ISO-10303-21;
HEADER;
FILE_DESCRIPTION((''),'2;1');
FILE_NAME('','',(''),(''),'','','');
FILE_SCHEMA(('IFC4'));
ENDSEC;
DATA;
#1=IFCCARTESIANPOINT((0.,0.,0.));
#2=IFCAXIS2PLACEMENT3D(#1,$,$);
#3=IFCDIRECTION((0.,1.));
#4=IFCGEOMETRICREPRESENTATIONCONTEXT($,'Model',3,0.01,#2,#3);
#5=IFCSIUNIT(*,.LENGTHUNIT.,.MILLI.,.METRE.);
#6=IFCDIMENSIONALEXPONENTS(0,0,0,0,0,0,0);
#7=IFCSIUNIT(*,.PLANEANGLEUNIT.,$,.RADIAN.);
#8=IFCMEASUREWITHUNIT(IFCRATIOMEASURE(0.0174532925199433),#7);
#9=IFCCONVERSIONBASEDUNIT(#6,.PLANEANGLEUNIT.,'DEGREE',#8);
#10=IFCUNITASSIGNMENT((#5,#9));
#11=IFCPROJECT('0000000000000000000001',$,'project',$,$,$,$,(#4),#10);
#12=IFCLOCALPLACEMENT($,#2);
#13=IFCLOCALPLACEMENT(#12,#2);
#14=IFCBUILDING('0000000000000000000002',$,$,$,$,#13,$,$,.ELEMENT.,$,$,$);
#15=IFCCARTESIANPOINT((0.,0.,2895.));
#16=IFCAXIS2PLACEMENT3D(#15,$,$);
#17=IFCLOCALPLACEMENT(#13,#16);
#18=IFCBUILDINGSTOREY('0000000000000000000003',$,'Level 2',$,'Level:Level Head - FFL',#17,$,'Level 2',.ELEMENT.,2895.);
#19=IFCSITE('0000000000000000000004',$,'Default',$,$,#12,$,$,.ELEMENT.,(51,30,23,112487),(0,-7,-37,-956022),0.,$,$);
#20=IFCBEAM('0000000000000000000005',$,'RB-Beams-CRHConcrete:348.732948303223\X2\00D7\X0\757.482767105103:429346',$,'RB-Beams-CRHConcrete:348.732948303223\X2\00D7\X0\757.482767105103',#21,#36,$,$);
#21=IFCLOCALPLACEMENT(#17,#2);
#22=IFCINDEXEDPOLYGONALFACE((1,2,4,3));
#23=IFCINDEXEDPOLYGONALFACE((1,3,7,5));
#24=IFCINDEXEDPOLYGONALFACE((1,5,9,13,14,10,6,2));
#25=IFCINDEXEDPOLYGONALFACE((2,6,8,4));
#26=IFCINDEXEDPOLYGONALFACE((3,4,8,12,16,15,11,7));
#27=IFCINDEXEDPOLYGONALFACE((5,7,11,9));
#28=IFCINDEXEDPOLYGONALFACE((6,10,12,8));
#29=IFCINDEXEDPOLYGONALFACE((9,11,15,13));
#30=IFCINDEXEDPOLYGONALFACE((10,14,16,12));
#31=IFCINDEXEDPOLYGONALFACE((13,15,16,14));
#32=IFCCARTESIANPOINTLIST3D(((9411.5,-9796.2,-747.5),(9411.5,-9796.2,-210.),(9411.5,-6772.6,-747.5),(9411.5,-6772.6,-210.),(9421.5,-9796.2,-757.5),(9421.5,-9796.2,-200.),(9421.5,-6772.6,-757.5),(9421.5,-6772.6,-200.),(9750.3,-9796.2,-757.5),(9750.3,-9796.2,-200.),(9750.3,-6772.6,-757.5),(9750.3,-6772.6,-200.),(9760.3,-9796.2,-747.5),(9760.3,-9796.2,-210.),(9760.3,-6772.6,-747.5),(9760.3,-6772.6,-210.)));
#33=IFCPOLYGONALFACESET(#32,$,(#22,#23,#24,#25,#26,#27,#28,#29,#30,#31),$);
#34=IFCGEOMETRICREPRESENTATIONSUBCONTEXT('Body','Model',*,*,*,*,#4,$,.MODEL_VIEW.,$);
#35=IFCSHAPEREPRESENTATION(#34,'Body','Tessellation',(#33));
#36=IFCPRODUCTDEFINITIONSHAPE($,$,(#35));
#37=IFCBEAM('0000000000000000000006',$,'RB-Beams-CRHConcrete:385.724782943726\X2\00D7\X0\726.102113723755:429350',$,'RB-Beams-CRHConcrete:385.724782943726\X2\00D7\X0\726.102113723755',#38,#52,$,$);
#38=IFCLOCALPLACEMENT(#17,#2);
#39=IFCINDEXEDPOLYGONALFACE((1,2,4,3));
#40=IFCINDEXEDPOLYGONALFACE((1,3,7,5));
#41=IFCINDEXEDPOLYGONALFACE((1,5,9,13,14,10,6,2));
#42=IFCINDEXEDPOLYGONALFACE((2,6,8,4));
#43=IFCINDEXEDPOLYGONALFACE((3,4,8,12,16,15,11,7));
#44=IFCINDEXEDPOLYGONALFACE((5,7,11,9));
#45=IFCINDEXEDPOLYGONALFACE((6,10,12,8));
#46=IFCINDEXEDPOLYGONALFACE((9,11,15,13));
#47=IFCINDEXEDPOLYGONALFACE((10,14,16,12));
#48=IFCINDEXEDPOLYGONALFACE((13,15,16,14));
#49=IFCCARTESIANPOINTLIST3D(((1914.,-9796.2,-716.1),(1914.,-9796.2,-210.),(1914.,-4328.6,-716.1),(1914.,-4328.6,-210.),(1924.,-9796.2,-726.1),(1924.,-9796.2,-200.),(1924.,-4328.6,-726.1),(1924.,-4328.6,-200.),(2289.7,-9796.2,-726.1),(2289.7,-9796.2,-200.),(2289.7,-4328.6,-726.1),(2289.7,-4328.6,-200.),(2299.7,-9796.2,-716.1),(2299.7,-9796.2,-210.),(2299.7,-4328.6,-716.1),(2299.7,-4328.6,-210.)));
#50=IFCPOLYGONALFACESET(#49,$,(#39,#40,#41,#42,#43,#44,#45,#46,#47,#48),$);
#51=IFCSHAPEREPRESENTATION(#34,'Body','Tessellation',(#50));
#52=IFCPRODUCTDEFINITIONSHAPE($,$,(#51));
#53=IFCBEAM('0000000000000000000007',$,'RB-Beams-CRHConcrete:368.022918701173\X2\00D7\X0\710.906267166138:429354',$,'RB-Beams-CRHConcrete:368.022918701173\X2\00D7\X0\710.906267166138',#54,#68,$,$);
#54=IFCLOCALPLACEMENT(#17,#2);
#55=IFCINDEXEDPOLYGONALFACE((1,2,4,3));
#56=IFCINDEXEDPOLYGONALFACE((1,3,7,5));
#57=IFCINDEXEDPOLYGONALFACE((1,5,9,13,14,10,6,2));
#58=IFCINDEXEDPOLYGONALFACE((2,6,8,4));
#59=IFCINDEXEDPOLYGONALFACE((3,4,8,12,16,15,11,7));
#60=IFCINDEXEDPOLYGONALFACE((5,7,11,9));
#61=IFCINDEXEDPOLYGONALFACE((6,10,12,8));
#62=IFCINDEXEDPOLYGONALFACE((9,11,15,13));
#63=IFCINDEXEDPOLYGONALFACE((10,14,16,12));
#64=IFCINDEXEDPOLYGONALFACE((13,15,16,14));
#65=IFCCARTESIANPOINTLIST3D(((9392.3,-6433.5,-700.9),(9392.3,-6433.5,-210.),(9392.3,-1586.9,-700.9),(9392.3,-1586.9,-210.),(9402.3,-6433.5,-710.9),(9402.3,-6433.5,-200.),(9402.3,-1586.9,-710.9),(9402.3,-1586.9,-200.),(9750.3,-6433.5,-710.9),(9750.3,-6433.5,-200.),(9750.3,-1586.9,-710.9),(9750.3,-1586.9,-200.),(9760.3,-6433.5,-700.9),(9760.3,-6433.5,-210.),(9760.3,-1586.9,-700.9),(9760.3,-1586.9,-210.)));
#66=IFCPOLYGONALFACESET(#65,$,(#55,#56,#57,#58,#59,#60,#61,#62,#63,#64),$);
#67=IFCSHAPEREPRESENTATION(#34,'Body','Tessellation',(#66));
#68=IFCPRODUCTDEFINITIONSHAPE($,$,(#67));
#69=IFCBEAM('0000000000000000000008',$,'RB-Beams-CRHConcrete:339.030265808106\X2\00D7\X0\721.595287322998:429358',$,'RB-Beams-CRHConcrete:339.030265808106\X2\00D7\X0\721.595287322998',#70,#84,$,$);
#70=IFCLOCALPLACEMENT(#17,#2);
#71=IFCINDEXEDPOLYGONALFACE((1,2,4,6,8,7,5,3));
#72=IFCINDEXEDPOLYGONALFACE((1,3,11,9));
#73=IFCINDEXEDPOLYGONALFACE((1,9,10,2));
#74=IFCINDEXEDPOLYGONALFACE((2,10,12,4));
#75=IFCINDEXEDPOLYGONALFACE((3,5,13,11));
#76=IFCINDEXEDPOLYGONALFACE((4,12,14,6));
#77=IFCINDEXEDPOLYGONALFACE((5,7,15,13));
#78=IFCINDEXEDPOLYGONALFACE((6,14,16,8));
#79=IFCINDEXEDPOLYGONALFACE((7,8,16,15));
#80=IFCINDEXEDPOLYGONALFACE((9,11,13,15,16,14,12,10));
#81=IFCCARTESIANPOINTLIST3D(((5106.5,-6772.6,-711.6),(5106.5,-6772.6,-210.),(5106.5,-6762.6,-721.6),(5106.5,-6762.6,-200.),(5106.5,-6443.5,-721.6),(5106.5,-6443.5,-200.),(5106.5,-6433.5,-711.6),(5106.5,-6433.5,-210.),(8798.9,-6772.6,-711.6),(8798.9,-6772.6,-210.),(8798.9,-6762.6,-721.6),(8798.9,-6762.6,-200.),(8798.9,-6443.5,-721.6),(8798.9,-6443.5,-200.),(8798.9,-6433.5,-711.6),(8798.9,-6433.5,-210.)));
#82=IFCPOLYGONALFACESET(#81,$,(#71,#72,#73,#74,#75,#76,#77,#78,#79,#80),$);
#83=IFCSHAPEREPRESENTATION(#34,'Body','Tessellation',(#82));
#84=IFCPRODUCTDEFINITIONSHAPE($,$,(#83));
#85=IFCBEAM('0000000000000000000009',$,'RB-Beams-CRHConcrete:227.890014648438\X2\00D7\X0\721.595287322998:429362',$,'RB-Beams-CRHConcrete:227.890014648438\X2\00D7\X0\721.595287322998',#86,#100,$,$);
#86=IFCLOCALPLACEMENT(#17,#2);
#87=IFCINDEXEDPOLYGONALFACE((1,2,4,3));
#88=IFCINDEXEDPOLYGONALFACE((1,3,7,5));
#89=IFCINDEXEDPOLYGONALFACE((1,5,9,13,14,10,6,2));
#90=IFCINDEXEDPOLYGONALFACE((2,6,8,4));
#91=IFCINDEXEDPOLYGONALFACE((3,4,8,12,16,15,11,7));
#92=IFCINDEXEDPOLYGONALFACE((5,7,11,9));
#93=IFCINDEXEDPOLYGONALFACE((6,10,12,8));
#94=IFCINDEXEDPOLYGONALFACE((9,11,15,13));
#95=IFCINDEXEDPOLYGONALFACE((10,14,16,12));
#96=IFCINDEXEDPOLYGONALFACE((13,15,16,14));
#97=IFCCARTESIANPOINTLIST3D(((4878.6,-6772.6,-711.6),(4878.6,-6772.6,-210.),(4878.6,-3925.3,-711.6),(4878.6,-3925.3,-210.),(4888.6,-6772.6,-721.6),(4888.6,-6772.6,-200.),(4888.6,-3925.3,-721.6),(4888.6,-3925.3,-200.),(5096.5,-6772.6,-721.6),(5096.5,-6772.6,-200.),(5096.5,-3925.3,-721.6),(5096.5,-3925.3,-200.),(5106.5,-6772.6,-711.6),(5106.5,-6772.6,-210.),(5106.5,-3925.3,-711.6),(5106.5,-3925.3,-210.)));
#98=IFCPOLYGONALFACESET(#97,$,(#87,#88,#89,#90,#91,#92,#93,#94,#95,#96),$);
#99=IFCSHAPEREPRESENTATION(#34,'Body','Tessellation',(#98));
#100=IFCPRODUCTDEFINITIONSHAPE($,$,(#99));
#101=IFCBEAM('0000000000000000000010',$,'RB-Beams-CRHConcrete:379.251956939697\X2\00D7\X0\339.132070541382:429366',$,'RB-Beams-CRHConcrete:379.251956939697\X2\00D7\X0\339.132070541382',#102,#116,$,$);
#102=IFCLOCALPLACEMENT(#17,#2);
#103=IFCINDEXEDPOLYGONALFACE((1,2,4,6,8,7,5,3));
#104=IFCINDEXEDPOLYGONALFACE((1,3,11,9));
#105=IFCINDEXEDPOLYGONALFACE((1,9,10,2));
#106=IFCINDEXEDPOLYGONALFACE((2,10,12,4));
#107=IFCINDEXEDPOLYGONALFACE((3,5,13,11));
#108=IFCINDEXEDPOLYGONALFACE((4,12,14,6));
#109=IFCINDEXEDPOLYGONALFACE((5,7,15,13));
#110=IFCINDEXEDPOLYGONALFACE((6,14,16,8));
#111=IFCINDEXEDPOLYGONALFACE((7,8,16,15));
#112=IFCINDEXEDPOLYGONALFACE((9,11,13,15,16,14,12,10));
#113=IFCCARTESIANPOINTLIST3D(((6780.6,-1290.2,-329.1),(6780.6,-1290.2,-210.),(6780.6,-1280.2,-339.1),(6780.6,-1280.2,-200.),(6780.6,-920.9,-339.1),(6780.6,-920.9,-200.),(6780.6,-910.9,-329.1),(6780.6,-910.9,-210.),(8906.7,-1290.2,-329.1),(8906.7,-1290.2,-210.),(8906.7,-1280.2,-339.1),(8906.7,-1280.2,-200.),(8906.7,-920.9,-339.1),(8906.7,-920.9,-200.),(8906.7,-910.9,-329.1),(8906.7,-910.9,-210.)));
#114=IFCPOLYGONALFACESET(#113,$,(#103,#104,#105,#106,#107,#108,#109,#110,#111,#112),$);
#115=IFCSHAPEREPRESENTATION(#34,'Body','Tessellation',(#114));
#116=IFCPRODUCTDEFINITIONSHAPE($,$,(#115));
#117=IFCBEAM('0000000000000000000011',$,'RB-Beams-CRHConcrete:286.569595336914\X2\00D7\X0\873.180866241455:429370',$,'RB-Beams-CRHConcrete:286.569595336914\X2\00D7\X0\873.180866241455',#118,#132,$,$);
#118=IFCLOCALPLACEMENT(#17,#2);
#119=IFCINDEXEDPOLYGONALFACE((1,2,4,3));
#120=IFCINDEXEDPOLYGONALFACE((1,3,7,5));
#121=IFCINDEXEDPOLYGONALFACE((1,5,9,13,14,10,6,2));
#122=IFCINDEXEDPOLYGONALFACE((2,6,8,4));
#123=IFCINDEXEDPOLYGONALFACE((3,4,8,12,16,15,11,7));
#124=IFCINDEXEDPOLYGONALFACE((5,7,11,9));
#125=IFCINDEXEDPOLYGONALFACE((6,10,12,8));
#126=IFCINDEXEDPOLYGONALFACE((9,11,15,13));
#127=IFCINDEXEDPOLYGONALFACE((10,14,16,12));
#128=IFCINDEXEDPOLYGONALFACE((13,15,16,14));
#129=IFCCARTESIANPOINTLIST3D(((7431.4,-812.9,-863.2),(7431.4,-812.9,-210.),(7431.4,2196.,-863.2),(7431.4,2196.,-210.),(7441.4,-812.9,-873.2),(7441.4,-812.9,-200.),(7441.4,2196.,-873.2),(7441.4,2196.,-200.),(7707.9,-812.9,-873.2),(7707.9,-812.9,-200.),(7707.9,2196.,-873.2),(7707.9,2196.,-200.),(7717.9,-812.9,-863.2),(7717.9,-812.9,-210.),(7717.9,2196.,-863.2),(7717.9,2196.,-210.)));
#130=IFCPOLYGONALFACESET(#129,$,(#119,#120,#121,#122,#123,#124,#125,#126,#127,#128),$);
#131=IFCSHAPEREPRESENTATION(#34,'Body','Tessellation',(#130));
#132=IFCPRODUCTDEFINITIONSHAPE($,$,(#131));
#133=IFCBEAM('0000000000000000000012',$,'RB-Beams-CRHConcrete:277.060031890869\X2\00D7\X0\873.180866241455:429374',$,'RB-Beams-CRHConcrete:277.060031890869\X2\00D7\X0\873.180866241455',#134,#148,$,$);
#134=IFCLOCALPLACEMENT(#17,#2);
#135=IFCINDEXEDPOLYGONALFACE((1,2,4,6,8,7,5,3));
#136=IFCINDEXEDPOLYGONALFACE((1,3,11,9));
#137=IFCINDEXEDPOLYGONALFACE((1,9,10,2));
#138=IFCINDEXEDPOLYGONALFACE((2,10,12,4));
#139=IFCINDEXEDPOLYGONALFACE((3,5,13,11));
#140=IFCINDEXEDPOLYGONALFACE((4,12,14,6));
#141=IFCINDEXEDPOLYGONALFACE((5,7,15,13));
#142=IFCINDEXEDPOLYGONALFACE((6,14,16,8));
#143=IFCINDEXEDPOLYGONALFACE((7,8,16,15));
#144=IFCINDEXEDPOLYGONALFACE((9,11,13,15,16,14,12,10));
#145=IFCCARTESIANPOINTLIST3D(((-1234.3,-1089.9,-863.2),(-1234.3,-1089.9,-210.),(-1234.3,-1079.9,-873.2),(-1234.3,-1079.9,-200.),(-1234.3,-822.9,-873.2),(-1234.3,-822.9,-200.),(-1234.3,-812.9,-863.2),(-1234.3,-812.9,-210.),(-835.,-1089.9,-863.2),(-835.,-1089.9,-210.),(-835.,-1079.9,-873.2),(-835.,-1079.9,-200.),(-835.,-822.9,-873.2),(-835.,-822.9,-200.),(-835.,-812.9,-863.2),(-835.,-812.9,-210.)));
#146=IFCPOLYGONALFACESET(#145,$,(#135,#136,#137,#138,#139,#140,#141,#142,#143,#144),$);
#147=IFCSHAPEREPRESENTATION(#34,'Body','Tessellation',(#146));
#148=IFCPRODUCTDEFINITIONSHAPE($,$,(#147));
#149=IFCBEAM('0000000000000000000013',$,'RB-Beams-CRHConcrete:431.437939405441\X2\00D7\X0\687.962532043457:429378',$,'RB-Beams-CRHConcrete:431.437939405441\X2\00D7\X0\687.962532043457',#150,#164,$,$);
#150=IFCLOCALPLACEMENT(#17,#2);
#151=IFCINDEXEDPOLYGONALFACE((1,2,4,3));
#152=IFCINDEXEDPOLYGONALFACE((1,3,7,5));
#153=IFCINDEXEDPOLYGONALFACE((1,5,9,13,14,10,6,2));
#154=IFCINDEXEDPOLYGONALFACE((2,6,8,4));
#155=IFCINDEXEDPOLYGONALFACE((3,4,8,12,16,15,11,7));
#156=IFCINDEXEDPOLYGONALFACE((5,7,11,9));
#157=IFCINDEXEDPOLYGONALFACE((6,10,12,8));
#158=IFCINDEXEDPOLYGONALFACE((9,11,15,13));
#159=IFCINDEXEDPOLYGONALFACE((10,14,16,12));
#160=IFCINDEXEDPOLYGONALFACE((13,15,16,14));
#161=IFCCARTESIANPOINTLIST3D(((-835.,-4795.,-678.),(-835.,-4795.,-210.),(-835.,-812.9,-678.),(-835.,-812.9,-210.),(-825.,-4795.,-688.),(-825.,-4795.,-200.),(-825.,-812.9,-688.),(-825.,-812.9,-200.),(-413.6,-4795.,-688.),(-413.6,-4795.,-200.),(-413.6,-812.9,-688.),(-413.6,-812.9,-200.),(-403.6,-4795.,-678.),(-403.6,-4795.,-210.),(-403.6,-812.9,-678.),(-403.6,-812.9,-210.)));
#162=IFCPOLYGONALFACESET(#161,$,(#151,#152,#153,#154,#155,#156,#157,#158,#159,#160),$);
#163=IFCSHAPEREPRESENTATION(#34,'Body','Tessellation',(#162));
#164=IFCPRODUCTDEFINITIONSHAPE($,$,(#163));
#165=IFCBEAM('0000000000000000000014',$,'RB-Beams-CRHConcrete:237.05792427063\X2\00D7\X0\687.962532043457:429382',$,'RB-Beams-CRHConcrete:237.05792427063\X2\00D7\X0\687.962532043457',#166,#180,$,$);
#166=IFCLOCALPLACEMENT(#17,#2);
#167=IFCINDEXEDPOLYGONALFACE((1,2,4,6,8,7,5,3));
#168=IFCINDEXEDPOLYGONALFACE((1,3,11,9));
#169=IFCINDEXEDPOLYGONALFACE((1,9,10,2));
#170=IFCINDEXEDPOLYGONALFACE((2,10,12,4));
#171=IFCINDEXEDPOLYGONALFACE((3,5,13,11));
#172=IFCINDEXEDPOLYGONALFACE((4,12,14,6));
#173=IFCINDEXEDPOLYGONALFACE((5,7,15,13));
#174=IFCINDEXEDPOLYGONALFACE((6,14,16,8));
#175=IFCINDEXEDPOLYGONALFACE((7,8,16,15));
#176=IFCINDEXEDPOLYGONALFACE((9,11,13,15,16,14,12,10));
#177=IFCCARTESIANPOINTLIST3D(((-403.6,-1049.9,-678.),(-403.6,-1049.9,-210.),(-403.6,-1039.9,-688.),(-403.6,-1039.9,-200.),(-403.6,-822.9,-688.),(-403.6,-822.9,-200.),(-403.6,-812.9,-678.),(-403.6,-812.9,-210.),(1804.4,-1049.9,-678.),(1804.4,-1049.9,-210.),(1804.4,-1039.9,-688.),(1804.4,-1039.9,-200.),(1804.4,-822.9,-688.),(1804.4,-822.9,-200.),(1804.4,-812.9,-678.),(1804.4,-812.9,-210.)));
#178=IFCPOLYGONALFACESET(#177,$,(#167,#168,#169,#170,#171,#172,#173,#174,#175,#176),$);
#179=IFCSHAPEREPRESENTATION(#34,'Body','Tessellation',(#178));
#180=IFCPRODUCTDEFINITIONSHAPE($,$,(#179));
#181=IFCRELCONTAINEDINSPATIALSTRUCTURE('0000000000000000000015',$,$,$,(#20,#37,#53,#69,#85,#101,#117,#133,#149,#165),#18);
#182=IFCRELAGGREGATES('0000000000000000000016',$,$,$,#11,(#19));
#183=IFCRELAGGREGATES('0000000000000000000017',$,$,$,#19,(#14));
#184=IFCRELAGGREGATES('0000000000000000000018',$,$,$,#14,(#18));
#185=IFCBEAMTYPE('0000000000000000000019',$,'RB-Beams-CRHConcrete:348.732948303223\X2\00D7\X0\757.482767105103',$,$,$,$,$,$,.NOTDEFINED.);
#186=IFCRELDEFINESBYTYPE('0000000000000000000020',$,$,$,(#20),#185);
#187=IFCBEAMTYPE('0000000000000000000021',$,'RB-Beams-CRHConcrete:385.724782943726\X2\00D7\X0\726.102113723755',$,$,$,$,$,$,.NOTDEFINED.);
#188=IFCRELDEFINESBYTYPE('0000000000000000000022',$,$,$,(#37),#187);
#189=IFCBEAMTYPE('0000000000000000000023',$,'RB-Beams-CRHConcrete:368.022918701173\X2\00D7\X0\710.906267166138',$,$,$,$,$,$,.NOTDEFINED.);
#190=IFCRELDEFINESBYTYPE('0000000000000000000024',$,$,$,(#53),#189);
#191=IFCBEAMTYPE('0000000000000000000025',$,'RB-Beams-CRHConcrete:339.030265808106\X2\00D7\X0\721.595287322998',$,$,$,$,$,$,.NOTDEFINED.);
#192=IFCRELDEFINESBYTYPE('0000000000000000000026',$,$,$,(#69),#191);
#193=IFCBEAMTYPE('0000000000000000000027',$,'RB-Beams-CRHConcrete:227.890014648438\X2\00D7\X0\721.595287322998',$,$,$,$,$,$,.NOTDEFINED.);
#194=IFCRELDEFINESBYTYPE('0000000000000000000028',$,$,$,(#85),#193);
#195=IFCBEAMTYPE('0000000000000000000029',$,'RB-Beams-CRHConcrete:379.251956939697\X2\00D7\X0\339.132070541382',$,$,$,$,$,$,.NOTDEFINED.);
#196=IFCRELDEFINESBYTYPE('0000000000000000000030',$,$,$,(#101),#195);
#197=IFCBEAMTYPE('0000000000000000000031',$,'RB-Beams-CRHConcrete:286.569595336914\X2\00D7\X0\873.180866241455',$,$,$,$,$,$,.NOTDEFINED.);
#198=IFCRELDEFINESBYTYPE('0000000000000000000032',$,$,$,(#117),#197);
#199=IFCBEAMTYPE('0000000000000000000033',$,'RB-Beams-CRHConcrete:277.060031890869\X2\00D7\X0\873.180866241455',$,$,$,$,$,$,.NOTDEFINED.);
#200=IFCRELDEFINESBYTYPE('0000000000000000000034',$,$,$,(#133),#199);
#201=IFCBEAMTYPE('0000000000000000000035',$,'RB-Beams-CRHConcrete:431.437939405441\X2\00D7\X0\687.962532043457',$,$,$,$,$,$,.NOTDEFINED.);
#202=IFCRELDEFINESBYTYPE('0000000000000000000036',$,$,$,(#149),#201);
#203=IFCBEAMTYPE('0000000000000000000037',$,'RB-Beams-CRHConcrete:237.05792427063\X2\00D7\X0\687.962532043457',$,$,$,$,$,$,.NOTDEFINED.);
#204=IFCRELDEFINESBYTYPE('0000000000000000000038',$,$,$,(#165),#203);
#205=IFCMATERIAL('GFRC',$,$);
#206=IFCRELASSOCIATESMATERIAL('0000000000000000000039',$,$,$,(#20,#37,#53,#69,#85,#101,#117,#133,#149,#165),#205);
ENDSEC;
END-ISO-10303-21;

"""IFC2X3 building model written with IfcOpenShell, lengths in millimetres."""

from ifc_helpers import new_model, entity, si_unit, converted_unit, direction, frame, origin, place, context, subcontext, project, spatial, polyline, outline, extrude, material, type_object, element, save


model = new_model("IFC2X3")

# Units and contexts
model_context = context("Model", 3, precision=0.01, world=origin(), true_north=direction((0.0, 1.0)))
body_context = subcontext(model_context, "Body", "Model", "MODEL_VIEW")
ifc_project = project(units=[si_unit("LENGTHUNIT", "METRE", prefix="MILLI"), converted_unit("PLANEANGLEUNIT", "DEGREE", entity("IfcRatioMeasure", 0.0174532925199433), si_unit("PLANEANGLEUNIT", "RADIAN"), dimensions=[0, 0, 0, 0, 0, 0, 0])], contexts=[model_context])

# Site, building, storey
site_placement = place(None, origin())
site = spatial("IfcSite", under=ifc_project, at=site_placement, Name="Default", CompositionType="ELEMENT", RefLatitude=(51, 30, 23, 112487), RefLongitude=(0, -7, -37, -956022), RefElevation=0.0)
building_placement = place(site_placement, origin())
building = spatial("IfcBuilding", under=site, at=building_placement, CompositionType="ELEMENT")
storey_placement = place(building_placement, frame((0.0, 0.0, 2895.0)))
storey = spatial("IfcBuildingStorey", under=building, at=storey_placement, Name="Level 2", ObjectType="Level:Level Head - FFL", LongName="Level 2", CompositionType="ELEMENT", Elevation=2895.0)

# Beams
ifc_material_1 = material(Name="GFRC")
beam_type_1 = type_object("IfcBeamType", Name="RB-Beams-CRHConcrete:348.732948303223×757.482767105103", PredefinedType="NOTDEFINED")
beam_1_placement = place(storey_placement, frame((9585.9, -9796.2, -200.0), z_axis=(0.0, 0.0, 1.0), x_axis=(0.0, 1.0, 0.0)))
element("IfcBeam", 1, at=beam_1_placement, inside=storey, type_object=beam_type_1, material=ifc_material_1, Name="RB-Beams-CRHConcrete:348.732948303223×757.482767105103:429346", ObjectType="RB-Beams-CRHConcrete:348.732948303223×757.482767105103", context=body_context, shape_type="SweptSolid", body=[
    extrude(outline(polyline([(-268.7, -174.4), (268.7, -174.4), (278.7, -164.4), (278.7, 164.4), (268.7, 174.4), (-268.7, 174.4), (-278.7, 164.4), (-278.7, -164.4), (-268.7, -174.4)])), frame((0.0, 0.0, -278.7), z_axis=(1.0, 0.0, 0.0), x_axis=(0.0, 0.0, -1.0)), (0.0, 0.0, 1.0), 3023.6),
])
beam_type_2 = type_object("IfcBeamType", Name="RB-Beams-CRHConcrete:385.724782943726×726.102113723755", PredefinedType="NOTDEFINED")
beam_2_placement = place(storey_placement, frame((2106.9, -9796.2, -200.0), z_axis=(0.0, 0.0, 1.0), x_axis=(0.0, 1.0, 0.0)))
element("IfcBeam", 2, at=beam_2_placement, inside=storey, type_object=beam_type_2, material=ifc_material_1, Name="RB-Beams-CRHConcrete:385.724782943726×726.102113723755:429350", ObjectType="RB-Beams-CRHConcrete:385.724782943726×726.102113723755", context=body_context, shape_type="SweptSolid", body=[
    extrude(outline(polyline([(-253.1, -192.9), (253.1, -192.9), (263.1, -182.9), (263.1, 182.9), (253.1, 192.9), (-253.1, 192.9), (-263.1, 182.9), (-263.1, -182.9), (-253.1, -192.9)])), frame((0.0, 0.0, -263.1), z_axis=(1.0, 0.0, 0.0), x_axis=(0.0, 0.0, -1.0)), (0.0, 0.0, 1.0), 5467.6),
])
beam_type_3 = type_object("IfcBeamType", Name="RB-Beams-CRHConcrete:368.022918701173×710.906267166138", PredefinedType="NOTDEFINED")
beam_3_placement = place(storey_placement, frame((9576.3, -6433.5, -200.0), z_axis=(0.0, 0.0, 1.0), x_axis=(0.0, 1.0, 0.0)))
element("IfcBeam", 3, at=beam_3_placement, inside=storey, type_object=beam_type_3, material=ifc_material_1, Name="RB-Beams-CRHConcrete:368.022918701173×710.906267166138:429354", ObjectType="RB-Beams-CRHConcrete:368.022918701173×710.906267166138", context=body_context, shape_type="SweptSolid", body=[
    extrude(outline(polyline([(-245.5, -184.0), (245.5, -184.0), (255.5, -174.0), (255.5, 174.0), (245.5, 184.0), (-245.5, 184.0), (-255.5, 174.0), (-255.5, -174.0), (-245.5, -184.0)])), frame((0.0, 0.0, -255.5), z_axis=(1.0, 0.0, 0.0), x_axis=(0.0, 0.0, -1.0)), (0.0, 0.0, 1.0), 4846.6),
])
beam_type_4 = type_object("IfcBeamType", Name="RB-Beams-CRHConcrete:339.030265808106×721.595287322998", PredefinedType="NOTDEFINED")
beam_4_placement = place(storey_placement, frame((5106.5, -6603.1, -200.0)))
element("IfcBeam", 4, at=beam_4_placement, inside=storey, type_object=beam_type_4, material=ifc_material_1, Name="RB-Beams-CRHConcrete:339.030265808106×721.595287322998:429358", ObjectType="RB-Beams-CRHConcrete:339.030265808106×721.595287322998", context=body_context, shape_type="SweptSolid", body=[
    extrude(outline(polyline([(-250.8, -169.5), (250.8, -169.5), (260.8, -159.5), (260.8, 159.5), (250.8, 169.5), (-250.8, 169.5), (-260.8, 159.5), (-260.8, -159.5), (-250.8, -169.5)])), frame((0.0, 0.0, -260.8), z_axis=(1.0, 0.0, 0.0), x_axis=(0.0, 0.0, -1.0)), (0.0, 0.0, 1.0), 3692.4),
])
beam_type_5 = type_object("IfcBeamType", Name="RB-Beams-CRHConcrete:227.890014648438×721.595287322998", PredefinedType="NOTDEFINED")
beam_5_placement = place(storey_placement, frame((4992.6, -6772.6, -200.0), z_axis=(0.0, 0.0, 1.0), x_axis=(0.0, 1.0, 0.0)))
element("IfcBeam", 5, at=beam_5_placement, inside=storey, type_object=beam_type_5, material=ifc_material_1, Name="RB-Beams-CRHConcrete:227.890014648438×721.595287322998:429362", ObjectType="RB-Beams-CRHConcrete:227.890014648438×721.595287322998", context=body_context, shape_type="SweptSolid", body=[
    extrude(outline(polyline([(-250.8, -113.9), (250.8, -113.9), (260.8, -103.9), (260.8, 103.9), (250.8, 113.9), (-250.8, 113.9), (-260.8, 103.9), (-260.8, -103.9), (-250.8, -113.9)])), frame((0.0, 0.0, -260.8), z_axis=(1.0, 0.0, 0.0), x_axis=(0.0, 0.0, -1.0)), (0.0, 0.0, 1.0), 2847.3),
])
beam_type_6 = type_object("IfcBeamType", Name="RB-Beams-CRHConcrete:379.251956939697×339.132070541382", PredefinedType="NOTDEFINED")
beam_6_placement = place(storey_placement, frame((6780.6, -1100.6, -200.0)))
element("IfcBeam", 6, at=beam_6_placement, inside=storey, type_object=beam_type_6, material=ifc_material_1, Name="RB-Beams-CRHConcrete:379.251956939697×339.132070541382:429366", ObjectType="RB-Beams-CRHConcrete:379.251956939697×339.132070541382", context=body_context, shape_type="SweptSolid", body=[
    extrude(outline(polyline([(-59.6, -189.6), (59.6, -189.6), (69.6, -179.6), (69.6, 179.6), (59.6, 189.6), (-59.6, 189.6), (-69.6, 179.6), (-69.6, -179.6), (-59.6, -189.6)])), frame((0.0, 0.0, -69.6), z_axis=(1.0, 0.0, 0.0), x_axis=(0.0, 0.0, -1.0)), (0.0, 0.0, 1.0), 2126.1),
])
beam_type_7 = type_object("IfcBeamType", Name="RB-Beams-CRHConcrete:286.569595336914×873.180866241455", PredefinedType="NOTDEFINED")
beam_7_placement = place(storey_placement, frame((7574.6, -812.9, -200.0), z_axis=(0.0, 0.0, 1.0), x_axis=(0.0, 1.0, 0.0)))
element("IfcBeam", 7, at=beam_7_placement, inside=storey, type_object=beam_type_7, material=ifc_material_1, Name="RB-Beams-CRHConcrete:286.569595336914×873.180866241455:429370", ObjectType="RB-Beams-CRHConcrete:286.569595336914×873.180866241455", context=body_context, shape_type="SweptSolid", body=[
    extrude(outline(polyline([(-326.6, -143.3), (326.6, -143.3), (336.6, -133.3), (336.6, 133.3), (326.6, 143.3), (-326.6, 143.3), (-336.6, 133.3), (-336.6, -133.3), (-326.6, -143.3)])), frame((0.0, 0.0, -336.6), z_axis=(1.0, 0.0, 0.0), x_axis=(0.0, 0.0, -1.0)), (0.0, 0.0, 1.0), 3008.8),
])
beam_type_8 = type_object("IfcBeamType", Name="RB-Beams-CRHConcrete:277.060031890869×873.180866241455", PredefinedType="NOTDEFINED")
beam_8_placement = place(storey_placement, frame((-1234.3, -951.4, -200.0)))
element("IfcBeam", 8, at=beam_8_placement, inside=storey, type_object=beam_type_8, material=ifc_material_1, Name="RB-Beams-CRHConcrete:277.060031890869×873.180866241455:429374", ObjectType="RB-Beams-CRHConcrete:277.060031890869×873.180866241455", context=body_context, shape_type="SweptSolid", body=[
    extrude(outline(polyline([(-326.6, -138.5), (326.6, -138.5), (336.6, -128.5), (336.6, 128.5), (326.6, 138.5), (-326.6, 138.5), (-336.6, 128.5), (-336.6, -128.5), (-326.6, -138.5)])), frame((0.0, 0.0, -336.6), z_axis=(1.0, 0.0, 0.0), x_axis=(0.0, 0.0, -1.0)), (0.0, 0.0, 1.0), 399.3),
])
beam_type_9 = type_object("IfcBeamType", Name="RB-Beams-CRHConcrete:431.437939405441×687.962532043457", PredefinedType="NOTDEFINED")
beam_9_placement = place(storey_placement, frame((-619.3, -4795.0, -200.0), z_axis=(0.0, 0.0, 1.0), x_axis=(0.0, 1.0, 0.0)))
element("IfcBeam", 9, at=beam_9_placement, inside=storey, type_object=beam_type_9, material=ifc_material_1, Name="RB-Beams-CRHConcrete:431.437939405441×687.962532043457:429378", ObjectType="RB-Beams-CRHConcrete:431.437939405441×687.962532043457", context=body_context, shape_type="SweptSolid", body=[
    extrude(outline(polyline([(-234.0, -215.7), (234.0, -215.7), (244.0, -205.7), (244.0, 205.7), (234.0, 215.7), (-234.0, 215.7), (-244.0, 205.7), (-244.0, -205.7), (-234.0, -215.7)])), frame((0.0, 0.0, -244.0), z_axis=(1.0, 0.0, 0.0), x_axis=(0.0, 0.0, -1.0)), (0.0, 0.0, 1.0), 3982.1),
])
beam_type_10 = type_object("IfcBeamType", Name="RB-Beams-CRHConcrete:237.05792427063×687.962532043457", PredefinedType="NOTDEFINED")
beam_10_placement = place(storey_placement, frame((-403.6, -931.4, -200.0)))
element("IfcBeam", 10, at=beam_10_placement, inside=storey, type_object=beam_type_10, material=ifc_material_1, Name="RB-Beams-CRHConcrete:237.05792427063×687.962532043457:429382", ObjectType="RB-Beams-CRHConcrete:237.05792427063×687.962532043457", context=body_context, shape_type="SweptSolid", body=[
    extrude(outline(polyline([(-234.0, -118.5), (234.0, -118.5), (244.0, -108.5), (244.0, 108.5), (234.0, 118.5), (-234.0, 118.5), (-244.0, 108.5), (-244.0, -108.5), (-234.0, -118.5)])), frame((0.0, 0.0, -244.0), z_axis=(1.0, 0.0, 0.0), x_axis=(0.0, 0.0, -1.0)), (0.0, 0.0, 1.0), 2207.9),
])

save(model, "model.ifc")
